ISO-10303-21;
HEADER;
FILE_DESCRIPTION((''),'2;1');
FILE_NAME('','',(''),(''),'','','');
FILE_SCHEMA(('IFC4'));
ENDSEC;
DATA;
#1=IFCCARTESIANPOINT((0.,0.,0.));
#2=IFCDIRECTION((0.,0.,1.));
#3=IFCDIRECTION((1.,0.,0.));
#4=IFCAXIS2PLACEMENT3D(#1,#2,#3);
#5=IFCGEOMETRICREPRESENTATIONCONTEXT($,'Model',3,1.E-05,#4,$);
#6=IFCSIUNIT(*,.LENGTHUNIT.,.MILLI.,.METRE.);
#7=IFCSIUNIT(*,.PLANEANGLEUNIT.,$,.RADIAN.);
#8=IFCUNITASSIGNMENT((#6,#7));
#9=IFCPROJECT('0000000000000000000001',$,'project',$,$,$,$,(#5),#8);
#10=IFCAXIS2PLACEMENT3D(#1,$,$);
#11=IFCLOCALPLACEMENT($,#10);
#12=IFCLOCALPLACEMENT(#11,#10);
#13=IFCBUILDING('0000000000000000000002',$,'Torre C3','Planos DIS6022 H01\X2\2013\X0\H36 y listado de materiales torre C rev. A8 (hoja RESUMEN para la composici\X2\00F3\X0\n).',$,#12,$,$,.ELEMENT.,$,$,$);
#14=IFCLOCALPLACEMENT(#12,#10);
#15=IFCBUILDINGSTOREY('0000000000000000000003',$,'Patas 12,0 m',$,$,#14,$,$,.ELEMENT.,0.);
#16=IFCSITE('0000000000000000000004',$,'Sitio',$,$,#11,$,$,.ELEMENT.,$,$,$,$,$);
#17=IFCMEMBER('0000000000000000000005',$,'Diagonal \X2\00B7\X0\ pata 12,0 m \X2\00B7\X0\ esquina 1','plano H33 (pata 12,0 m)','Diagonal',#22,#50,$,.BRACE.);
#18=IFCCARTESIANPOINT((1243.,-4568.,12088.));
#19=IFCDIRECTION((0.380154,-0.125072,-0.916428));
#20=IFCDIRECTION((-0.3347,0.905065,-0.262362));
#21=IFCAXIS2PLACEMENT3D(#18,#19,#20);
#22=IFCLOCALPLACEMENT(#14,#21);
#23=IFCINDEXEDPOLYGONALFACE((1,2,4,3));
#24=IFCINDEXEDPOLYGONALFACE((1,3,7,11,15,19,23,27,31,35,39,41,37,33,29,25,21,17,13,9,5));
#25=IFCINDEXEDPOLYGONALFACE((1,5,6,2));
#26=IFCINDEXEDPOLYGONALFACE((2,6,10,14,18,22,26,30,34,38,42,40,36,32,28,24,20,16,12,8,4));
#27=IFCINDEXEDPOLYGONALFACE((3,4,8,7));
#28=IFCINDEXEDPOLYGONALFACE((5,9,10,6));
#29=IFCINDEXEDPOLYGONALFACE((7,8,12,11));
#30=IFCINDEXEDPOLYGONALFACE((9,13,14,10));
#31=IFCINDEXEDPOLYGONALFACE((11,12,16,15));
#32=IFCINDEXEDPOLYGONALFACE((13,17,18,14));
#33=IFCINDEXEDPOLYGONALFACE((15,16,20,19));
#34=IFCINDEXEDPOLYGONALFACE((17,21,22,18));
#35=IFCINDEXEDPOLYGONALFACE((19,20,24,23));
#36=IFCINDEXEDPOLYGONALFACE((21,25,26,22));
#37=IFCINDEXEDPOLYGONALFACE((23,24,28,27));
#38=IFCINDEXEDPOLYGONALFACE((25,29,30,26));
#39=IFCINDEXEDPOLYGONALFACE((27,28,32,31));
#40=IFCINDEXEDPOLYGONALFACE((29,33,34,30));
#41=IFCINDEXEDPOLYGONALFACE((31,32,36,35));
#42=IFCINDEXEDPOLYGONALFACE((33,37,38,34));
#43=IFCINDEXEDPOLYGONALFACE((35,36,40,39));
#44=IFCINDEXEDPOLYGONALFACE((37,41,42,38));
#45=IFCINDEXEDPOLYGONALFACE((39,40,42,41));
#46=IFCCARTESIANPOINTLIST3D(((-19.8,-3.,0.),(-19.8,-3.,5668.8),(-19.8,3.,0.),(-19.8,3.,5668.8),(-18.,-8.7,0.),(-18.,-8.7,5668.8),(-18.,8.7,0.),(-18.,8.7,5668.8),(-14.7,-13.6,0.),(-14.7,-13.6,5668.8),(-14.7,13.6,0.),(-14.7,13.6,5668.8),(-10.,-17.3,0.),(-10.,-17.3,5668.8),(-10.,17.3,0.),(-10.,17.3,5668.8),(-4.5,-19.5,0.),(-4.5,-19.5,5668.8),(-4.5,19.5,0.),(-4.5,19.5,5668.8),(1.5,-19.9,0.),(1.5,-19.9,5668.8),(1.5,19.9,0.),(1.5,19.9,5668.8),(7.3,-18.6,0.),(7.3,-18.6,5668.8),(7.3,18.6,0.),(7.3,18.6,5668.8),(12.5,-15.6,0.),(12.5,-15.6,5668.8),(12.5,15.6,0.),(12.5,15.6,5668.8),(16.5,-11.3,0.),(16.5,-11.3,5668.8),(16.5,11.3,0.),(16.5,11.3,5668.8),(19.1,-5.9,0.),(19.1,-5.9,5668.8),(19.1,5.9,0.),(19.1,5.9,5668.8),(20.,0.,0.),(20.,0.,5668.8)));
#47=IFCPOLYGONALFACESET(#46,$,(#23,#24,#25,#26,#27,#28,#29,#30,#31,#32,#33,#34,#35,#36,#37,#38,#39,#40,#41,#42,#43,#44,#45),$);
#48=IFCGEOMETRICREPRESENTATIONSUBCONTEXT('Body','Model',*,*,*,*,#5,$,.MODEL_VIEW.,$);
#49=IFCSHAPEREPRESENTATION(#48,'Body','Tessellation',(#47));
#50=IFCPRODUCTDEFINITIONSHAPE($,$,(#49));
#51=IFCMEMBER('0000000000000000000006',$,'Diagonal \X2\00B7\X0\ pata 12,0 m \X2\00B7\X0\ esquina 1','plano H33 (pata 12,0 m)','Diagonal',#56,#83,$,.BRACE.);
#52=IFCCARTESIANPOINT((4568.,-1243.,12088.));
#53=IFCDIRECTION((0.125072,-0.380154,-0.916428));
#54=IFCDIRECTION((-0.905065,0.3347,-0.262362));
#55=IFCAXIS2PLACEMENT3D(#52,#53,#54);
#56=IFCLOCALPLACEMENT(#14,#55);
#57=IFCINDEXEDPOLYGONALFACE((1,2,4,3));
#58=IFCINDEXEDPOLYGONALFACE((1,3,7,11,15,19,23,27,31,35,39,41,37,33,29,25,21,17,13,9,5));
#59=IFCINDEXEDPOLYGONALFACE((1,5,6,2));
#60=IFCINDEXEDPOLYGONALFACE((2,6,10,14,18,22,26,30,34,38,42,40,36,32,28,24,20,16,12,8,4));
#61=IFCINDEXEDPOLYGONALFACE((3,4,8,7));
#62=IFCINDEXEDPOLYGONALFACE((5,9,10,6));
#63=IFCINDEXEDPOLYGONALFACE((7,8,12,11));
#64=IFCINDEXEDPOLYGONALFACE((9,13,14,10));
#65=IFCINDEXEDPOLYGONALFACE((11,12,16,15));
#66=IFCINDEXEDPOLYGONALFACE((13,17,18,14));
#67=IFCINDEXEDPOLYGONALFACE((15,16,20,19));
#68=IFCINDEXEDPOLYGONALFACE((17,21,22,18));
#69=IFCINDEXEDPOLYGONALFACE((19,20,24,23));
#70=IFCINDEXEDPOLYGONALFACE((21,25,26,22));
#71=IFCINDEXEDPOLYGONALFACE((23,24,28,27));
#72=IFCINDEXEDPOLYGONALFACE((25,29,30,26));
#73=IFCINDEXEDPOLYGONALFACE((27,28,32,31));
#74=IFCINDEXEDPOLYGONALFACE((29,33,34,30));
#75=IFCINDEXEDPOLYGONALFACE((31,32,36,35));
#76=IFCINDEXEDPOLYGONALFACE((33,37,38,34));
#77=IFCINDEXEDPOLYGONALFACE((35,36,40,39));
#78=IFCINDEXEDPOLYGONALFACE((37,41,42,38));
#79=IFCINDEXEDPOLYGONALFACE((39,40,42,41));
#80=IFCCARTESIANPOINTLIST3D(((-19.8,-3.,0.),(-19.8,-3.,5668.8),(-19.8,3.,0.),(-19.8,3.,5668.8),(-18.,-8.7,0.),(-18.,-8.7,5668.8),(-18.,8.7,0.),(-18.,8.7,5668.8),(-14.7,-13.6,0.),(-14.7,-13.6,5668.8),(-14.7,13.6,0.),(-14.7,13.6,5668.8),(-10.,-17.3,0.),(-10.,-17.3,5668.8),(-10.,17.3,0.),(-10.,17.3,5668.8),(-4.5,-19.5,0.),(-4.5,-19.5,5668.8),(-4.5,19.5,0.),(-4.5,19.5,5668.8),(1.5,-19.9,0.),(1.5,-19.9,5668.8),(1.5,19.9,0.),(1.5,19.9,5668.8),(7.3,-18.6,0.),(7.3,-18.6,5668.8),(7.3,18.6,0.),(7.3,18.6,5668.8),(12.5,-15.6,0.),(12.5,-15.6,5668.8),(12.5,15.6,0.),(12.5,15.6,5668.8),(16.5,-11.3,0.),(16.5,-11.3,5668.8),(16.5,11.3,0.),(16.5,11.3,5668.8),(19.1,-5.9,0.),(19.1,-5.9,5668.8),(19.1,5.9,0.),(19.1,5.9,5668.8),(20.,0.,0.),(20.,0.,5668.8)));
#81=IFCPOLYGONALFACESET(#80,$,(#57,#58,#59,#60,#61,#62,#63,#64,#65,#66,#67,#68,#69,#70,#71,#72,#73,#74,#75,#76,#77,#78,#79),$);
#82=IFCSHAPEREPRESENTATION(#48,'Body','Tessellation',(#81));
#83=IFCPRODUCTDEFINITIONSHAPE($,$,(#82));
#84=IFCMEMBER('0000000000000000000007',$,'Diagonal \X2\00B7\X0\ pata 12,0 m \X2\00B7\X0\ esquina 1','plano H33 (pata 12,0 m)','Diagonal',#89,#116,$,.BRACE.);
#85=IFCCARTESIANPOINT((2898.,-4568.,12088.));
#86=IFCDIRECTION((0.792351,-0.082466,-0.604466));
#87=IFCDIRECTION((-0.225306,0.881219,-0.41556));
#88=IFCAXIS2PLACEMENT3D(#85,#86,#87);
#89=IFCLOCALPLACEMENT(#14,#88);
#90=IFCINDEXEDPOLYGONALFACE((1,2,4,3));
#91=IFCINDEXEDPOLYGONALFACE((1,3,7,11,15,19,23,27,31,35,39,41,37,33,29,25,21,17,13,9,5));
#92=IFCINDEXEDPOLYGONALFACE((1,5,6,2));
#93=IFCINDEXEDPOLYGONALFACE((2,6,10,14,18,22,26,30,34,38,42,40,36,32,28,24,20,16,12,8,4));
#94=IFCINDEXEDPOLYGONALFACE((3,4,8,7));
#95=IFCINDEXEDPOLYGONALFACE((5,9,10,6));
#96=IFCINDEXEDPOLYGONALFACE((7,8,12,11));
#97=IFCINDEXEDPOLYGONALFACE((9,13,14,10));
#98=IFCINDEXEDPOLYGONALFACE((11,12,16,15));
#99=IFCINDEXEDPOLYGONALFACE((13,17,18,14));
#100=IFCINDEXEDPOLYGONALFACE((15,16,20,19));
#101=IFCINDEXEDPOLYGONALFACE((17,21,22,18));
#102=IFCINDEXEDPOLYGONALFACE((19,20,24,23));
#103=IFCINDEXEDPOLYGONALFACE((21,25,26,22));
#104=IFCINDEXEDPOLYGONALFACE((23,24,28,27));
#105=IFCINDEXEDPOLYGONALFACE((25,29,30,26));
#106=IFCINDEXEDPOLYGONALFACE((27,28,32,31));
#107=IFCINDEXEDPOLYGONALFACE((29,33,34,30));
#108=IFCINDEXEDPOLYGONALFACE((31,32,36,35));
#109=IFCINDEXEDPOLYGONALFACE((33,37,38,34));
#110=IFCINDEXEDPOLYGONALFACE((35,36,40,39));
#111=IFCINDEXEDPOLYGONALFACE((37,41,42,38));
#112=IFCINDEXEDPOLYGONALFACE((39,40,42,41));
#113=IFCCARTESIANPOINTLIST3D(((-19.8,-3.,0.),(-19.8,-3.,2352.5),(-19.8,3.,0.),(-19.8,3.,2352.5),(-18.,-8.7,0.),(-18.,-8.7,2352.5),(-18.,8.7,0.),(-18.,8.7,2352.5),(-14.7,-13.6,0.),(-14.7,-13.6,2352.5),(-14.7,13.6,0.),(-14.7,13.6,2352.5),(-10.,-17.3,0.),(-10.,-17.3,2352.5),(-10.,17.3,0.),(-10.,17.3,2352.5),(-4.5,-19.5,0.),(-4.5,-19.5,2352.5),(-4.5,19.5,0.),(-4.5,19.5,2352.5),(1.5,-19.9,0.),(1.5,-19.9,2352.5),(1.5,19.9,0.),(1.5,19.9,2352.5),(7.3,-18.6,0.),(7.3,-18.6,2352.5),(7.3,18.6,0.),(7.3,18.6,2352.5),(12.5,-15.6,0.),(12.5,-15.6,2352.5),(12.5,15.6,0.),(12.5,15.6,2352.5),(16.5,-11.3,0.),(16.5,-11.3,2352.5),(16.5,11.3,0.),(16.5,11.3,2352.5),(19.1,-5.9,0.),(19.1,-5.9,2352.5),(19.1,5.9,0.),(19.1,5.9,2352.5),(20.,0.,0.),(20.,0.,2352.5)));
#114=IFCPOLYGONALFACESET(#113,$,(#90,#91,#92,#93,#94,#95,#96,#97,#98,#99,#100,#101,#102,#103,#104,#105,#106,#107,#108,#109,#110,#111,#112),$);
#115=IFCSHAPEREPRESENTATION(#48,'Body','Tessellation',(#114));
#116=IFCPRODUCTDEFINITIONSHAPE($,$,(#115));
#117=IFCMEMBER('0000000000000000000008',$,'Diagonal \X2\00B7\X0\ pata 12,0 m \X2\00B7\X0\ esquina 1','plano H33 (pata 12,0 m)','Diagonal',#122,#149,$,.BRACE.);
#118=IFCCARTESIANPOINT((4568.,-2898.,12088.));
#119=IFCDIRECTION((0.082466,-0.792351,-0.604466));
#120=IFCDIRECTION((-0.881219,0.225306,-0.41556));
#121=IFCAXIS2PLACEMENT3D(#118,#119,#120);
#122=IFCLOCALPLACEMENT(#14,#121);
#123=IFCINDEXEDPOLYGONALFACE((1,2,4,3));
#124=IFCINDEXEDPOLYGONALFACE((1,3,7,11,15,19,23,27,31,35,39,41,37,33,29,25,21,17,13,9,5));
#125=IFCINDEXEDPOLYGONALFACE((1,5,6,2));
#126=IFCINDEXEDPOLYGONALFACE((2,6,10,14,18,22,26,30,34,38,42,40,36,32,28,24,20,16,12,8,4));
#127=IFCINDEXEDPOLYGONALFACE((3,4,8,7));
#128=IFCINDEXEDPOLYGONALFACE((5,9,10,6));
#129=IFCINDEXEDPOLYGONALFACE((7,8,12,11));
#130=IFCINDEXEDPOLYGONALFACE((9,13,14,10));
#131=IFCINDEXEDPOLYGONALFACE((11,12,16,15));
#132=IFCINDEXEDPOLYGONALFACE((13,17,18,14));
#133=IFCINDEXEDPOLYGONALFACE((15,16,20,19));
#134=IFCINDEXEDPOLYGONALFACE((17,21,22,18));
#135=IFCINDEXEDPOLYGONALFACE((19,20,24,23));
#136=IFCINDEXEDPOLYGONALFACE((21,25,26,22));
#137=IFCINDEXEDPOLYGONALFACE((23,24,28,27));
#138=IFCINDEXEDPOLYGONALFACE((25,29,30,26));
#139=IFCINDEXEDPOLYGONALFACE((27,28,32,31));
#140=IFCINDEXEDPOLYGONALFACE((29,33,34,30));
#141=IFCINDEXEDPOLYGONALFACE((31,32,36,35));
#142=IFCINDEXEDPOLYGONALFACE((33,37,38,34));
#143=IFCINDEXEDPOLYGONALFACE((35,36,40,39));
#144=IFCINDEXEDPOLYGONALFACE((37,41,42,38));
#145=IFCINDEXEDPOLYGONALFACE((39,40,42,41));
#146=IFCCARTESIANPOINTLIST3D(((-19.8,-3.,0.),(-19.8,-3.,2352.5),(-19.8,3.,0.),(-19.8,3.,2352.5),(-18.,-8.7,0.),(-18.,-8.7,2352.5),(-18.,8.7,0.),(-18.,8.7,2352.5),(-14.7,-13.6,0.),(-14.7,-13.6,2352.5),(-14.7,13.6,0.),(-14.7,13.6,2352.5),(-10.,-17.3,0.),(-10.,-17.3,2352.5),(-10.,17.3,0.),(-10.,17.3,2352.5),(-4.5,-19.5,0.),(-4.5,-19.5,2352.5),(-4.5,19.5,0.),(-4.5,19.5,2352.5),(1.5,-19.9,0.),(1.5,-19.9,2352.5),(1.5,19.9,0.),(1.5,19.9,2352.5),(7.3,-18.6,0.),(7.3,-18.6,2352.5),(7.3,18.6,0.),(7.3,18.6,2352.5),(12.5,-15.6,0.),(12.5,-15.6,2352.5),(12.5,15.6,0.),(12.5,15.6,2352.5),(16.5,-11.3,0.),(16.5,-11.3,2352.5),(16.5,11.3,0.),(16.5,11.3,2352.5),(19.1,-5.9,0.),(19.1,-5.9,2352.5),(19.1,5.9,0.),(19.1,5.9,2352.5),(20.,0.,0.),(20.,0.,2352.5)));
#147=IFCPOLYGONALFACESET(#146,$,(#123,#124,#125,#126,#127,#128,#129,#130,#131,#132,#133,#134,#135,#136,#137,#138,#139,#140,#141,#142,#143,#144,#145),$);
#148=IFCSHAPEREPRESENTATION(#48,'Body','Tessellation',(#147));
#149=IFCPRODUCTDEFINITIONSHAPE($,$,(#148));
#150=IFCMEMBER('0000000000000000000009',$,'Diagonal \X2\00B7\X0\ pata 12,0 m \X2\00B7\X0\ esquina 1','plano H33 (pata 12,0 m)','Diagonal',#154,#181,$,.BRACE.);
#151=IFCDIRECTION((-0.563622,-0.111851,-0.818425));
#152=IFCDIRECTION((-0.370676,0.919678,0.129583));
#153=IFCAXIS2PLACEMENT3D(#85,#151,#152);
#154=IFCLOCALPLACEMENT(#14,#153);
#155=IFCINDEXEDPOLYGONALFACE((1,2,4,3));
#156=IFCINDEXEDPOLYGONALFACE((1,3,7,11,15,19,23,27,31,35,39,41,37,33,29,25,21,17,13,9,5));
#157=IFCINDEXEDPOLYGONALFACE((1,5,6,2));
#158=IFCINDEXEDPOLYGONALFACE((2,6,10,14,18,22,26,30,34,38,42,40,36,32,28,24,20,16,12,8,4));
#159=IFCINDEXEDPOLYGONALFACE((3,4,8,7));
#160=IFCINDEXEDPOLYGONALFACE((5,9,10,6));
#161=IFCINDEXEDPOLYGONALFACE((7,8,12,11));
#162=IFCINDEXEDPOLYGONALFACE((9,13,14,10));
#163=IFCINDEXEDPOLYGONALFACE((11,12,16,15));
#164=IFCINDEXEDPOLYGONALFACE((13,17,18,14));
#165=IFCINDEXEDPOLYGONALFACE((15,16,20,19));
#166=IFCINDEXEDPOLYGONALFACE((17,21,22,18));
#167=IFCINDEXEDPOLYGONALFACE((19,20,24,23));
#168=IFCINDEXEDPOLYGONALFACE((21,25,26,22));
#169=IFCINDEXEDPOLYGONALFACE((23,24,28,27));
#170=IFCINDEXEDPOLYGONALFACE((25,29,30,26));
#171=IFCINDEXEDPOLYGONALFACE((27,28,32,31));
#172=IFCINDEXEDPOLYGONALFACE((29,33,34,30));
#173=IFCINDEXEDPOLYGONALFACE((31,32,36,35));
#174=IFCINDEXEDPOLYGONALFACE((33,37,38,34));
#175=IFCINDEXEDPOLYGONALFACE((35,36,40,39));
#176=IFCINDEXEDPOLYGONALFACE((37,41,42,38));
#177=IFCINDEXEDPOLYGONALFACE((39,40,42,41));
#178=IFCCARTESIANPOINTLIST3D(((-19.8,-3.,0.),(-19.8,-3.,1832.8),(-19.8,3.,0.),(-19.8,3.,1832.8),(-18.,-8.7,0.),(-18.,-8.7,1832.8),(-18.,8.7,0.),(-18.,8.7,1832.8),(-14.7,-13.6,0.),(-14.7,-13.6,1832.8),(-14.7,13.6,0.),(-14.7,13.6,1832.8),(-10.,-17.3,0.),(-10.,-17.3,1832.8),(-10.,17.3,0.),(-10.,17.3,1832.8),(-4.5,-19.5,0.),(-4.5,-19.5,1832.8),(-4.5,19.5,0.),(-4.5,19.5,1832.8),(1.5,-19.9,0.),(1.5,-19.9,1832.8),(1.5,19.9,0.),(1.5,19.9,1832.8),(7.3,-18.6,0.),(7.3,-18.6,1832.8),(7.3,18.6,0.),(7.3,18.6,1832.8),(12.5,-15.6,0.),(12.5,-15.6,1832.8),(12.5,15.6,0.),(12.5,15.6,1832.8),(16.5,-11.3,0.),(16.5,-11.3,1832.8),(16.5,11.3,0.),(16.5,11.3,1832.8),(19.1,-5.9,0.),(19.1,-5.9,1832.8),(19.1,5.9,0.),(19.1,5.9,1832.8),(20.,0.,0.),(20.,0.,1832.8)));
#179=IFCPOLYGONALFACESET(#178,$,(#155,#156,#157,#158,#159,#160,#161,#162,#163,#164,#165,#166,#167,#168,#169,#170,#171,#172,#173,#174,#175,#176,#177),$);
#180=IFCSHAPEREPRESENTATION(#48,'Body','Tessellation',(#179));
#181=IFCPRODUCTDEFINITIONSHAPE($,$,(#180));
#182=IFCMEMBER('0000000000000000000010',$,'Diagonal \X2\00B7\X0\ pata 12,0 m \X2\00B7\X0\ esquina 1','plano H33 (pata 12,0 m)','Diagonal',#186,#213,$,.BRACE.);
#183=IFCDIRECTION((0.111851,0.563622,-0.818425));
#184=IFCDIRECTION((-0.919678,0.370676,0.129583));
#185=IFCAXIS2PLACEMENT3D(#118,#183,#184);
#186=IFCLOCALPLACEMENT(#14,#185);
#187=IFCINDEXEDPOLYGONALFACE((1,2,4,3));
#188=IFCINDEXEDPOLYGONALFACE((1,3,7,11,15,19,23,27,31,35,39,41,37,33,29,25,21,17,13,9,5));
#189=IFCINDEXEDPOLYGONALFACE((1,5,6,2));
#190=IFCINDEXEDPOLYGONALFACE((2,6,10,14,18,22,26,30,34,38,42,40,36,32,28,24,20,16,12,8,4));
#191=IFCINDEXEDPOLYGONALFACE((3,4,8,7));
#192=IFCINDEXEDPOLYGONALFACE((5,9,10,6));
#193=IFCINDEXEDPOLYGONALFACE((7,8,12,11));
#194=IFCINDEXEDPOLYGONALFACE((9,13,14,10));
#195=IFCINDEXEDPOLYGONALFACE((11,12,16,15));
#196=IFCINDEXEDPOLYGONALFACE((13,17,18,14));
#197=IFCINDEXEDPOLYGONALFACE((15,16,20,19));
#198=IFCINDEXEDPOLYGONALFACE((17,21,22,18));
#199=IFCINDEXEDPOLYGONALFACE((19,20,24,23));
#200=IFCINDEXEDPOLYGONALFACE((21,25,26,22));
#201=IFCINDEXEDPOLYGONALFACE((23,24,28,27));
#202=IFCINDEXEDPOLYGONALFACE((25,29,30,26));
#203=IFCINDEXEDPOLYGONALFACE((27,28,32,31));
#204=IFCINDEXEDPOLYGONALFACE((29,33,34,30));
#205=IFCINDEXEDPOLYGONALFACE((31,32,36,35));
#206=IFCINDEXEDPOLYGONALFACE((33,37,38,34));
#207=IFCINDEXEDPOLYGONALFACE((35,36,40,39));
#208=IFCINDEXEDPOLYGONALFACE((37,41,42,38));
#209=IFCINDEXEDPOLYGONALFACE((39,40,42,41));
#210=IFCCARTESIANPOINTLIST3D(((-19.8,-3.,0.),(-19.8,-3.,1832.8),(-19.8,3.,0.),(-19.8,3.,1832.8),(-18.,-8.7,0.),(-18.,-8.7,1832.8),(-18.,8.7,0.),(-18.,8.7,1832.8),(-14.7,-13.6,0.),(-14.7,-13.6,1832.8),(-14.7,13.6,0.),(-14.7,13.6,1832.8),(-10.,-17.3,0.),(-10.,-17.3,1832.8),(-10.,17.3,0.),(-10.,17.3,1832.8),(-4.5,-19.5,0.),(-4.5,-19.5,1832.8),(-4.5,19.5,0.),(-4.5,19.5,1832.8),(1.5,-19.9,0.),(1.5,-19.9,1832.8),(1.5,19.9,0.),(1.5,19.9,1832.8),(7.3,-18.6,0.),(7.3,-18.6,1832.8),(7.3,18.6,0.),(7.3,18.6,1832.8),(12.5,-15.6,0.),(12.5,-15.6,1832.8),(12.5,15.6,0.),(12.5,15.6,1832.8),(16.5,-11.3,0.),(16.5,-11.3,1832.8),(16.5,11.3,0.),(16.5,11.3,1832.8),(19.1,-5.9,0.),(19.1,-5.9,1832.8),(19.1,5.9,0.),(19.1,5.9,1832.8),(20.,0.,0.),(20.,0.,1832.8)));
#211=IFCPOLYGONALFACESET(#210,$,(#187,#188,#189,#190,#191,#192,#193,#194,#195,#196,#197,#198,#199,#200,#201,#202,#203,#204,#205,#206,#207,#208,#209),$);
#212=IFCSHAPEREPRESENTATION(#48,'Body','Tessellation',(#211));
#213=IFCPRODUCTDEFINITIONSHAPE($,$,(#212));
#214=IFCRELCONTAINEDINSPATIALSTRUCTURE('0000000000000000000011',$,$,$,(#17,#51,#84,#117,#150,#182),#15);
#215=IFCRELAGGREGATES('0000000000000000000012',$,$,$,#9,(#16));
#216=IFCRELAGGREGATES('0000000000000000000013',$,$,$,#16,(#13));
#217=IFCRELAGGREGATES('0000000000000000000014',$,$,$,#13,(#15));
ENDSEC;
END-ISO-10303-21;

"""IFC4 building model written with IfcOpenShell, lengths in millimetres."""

from ifc_helpers import new_model, si_unit, frame, origin, origin_with_axes, place, context, subcontext, project, spatial, circle, extrude, element, save


model = new_model("IFC4")

# Units and contexts
model_context = context("Model", 3, precision=1e-05, world=origin_with_axes())
body_context = subcontext(model_context, "Body", "Model", "MODEL_VIEW")
ifc_project = project(units=[si_unit("LENGTHUNIT", "METRE", prefix="MILLI"), si_unit("PLANEANGLEUNIT", "RADIAN")], contexts=[model_context])

# Site, building, storey
site_placement = place(None, origin())
site = spatial("IfcSite", under=ifc_project, at=site_placement, Name="Sitio", CompositionType="ELEMENT")
building_placement = place(site_placement, origin())
building = spatial("IfcBuilding", under=site, at=building_placement, Name="Torre C3", Description="Planos DIS6022 H01–H36 y listado de materiales torre C rev. A8 (hoja RESUMEN para la composición).", CompositionType="ELEMENT")
storey_placement = place(building_placement, origin())
storey = spatial("IfcBuildingStorey", under=building, at=storey_placement, Name="Patas 12,0 m", CompositionType="ELEMENT", Elevation=0.0)

# Members
for number, where, z_axis, x_axis, name in (
    (1, (1243.0, -4568.0, 12088.0), (0.380154, -0.125072, -0.916428), (-0.3347, 0.905065, -0.262362), "Diagonal · pata 12,0 m · esquina 1"),
    (2, (4568.0, -1243.0, 12088.0), (0.125072, -0.380154, -0.916428), (-0.905065, 0.3347, -0.262362), "Diagonal · pata 12,0 m · esquina 1"),
):
    element("IfcMember", number, at=place(storey_placement, frame(where, z_axis=z_axis, x_axis=x_axis)), inside=storey, Name=name, Description="plano H33 (pata 12,0 m)", ObjectType="Diagonal", PredefinedType="BRACE", context=body_context, shape_type="SweptSolid", body=[
        extrude(circle(Radius=20.0), None, (0.0, 0.0, 1.0), 5668.8),
    ])
for number, where, z_axis, x_axis, name in (
    (3, (2898.0, -4568.0, 12088.0), (0.792351, -0.082466, -0.604466), (-0.225306, 0.881219, -0.41556), "Diagonal · pata 12,0 m · esquina 1"),
    (4, (4568.0, -2898.0, 12088.0), (0.082466, -0.792351, -0.604466), (-0.881219, 0.225306, -0.41556), "Diagonal · pata 12,0 m · esquina 1"),
):
    element("IfcMember", number, at=place(storey_placement, frame(where, z_axis=z_axis, x_axis=x_axis)), inside=storey, Name=name, Description="plano H33 (pata 12,0 m)", ObjectType="Diagonal", PredefinedType="BRACE", context=body_context, shape_type="SweptSolid", body=[
        extrude(circle(Radius=20.0), None, (0.0, 0.0, 1.0), 2352.5),
    ])
for number, where, z_axis, x_axis, name in (
    (5, (2898.0, -4568.0, 12088.0), (-0.563622, -0.111851, -0.818425), (-0.370676, 0.919678, 0.129583), "Diagonal · pata 12,0 m · esquina 1"),
    (6, (4568.0, -2898.0, 12088.0), (0.111851, 0.563622, -0.818425), (-0.919678, 0.370676, 0.129583), "Diagonal · pata 12,0 m · esquina 1"),
):
    element("IfcMember", number, at=place(storey_placement, frame(where, z_axis=z_axis, x_axis=x_axis)), inside=storey, Name=name, Description="plano H33 (pata 12,0 m)", ObjectType="Diagonal", PredefinedType="BRACE", context=body_context, shape_type="SweptSolid", body=[
        extrude(circle(Radius=20.0), None, (0.0, 0.0, 1.0), 1832.8),
    ])

save(model, "model.ifc")
